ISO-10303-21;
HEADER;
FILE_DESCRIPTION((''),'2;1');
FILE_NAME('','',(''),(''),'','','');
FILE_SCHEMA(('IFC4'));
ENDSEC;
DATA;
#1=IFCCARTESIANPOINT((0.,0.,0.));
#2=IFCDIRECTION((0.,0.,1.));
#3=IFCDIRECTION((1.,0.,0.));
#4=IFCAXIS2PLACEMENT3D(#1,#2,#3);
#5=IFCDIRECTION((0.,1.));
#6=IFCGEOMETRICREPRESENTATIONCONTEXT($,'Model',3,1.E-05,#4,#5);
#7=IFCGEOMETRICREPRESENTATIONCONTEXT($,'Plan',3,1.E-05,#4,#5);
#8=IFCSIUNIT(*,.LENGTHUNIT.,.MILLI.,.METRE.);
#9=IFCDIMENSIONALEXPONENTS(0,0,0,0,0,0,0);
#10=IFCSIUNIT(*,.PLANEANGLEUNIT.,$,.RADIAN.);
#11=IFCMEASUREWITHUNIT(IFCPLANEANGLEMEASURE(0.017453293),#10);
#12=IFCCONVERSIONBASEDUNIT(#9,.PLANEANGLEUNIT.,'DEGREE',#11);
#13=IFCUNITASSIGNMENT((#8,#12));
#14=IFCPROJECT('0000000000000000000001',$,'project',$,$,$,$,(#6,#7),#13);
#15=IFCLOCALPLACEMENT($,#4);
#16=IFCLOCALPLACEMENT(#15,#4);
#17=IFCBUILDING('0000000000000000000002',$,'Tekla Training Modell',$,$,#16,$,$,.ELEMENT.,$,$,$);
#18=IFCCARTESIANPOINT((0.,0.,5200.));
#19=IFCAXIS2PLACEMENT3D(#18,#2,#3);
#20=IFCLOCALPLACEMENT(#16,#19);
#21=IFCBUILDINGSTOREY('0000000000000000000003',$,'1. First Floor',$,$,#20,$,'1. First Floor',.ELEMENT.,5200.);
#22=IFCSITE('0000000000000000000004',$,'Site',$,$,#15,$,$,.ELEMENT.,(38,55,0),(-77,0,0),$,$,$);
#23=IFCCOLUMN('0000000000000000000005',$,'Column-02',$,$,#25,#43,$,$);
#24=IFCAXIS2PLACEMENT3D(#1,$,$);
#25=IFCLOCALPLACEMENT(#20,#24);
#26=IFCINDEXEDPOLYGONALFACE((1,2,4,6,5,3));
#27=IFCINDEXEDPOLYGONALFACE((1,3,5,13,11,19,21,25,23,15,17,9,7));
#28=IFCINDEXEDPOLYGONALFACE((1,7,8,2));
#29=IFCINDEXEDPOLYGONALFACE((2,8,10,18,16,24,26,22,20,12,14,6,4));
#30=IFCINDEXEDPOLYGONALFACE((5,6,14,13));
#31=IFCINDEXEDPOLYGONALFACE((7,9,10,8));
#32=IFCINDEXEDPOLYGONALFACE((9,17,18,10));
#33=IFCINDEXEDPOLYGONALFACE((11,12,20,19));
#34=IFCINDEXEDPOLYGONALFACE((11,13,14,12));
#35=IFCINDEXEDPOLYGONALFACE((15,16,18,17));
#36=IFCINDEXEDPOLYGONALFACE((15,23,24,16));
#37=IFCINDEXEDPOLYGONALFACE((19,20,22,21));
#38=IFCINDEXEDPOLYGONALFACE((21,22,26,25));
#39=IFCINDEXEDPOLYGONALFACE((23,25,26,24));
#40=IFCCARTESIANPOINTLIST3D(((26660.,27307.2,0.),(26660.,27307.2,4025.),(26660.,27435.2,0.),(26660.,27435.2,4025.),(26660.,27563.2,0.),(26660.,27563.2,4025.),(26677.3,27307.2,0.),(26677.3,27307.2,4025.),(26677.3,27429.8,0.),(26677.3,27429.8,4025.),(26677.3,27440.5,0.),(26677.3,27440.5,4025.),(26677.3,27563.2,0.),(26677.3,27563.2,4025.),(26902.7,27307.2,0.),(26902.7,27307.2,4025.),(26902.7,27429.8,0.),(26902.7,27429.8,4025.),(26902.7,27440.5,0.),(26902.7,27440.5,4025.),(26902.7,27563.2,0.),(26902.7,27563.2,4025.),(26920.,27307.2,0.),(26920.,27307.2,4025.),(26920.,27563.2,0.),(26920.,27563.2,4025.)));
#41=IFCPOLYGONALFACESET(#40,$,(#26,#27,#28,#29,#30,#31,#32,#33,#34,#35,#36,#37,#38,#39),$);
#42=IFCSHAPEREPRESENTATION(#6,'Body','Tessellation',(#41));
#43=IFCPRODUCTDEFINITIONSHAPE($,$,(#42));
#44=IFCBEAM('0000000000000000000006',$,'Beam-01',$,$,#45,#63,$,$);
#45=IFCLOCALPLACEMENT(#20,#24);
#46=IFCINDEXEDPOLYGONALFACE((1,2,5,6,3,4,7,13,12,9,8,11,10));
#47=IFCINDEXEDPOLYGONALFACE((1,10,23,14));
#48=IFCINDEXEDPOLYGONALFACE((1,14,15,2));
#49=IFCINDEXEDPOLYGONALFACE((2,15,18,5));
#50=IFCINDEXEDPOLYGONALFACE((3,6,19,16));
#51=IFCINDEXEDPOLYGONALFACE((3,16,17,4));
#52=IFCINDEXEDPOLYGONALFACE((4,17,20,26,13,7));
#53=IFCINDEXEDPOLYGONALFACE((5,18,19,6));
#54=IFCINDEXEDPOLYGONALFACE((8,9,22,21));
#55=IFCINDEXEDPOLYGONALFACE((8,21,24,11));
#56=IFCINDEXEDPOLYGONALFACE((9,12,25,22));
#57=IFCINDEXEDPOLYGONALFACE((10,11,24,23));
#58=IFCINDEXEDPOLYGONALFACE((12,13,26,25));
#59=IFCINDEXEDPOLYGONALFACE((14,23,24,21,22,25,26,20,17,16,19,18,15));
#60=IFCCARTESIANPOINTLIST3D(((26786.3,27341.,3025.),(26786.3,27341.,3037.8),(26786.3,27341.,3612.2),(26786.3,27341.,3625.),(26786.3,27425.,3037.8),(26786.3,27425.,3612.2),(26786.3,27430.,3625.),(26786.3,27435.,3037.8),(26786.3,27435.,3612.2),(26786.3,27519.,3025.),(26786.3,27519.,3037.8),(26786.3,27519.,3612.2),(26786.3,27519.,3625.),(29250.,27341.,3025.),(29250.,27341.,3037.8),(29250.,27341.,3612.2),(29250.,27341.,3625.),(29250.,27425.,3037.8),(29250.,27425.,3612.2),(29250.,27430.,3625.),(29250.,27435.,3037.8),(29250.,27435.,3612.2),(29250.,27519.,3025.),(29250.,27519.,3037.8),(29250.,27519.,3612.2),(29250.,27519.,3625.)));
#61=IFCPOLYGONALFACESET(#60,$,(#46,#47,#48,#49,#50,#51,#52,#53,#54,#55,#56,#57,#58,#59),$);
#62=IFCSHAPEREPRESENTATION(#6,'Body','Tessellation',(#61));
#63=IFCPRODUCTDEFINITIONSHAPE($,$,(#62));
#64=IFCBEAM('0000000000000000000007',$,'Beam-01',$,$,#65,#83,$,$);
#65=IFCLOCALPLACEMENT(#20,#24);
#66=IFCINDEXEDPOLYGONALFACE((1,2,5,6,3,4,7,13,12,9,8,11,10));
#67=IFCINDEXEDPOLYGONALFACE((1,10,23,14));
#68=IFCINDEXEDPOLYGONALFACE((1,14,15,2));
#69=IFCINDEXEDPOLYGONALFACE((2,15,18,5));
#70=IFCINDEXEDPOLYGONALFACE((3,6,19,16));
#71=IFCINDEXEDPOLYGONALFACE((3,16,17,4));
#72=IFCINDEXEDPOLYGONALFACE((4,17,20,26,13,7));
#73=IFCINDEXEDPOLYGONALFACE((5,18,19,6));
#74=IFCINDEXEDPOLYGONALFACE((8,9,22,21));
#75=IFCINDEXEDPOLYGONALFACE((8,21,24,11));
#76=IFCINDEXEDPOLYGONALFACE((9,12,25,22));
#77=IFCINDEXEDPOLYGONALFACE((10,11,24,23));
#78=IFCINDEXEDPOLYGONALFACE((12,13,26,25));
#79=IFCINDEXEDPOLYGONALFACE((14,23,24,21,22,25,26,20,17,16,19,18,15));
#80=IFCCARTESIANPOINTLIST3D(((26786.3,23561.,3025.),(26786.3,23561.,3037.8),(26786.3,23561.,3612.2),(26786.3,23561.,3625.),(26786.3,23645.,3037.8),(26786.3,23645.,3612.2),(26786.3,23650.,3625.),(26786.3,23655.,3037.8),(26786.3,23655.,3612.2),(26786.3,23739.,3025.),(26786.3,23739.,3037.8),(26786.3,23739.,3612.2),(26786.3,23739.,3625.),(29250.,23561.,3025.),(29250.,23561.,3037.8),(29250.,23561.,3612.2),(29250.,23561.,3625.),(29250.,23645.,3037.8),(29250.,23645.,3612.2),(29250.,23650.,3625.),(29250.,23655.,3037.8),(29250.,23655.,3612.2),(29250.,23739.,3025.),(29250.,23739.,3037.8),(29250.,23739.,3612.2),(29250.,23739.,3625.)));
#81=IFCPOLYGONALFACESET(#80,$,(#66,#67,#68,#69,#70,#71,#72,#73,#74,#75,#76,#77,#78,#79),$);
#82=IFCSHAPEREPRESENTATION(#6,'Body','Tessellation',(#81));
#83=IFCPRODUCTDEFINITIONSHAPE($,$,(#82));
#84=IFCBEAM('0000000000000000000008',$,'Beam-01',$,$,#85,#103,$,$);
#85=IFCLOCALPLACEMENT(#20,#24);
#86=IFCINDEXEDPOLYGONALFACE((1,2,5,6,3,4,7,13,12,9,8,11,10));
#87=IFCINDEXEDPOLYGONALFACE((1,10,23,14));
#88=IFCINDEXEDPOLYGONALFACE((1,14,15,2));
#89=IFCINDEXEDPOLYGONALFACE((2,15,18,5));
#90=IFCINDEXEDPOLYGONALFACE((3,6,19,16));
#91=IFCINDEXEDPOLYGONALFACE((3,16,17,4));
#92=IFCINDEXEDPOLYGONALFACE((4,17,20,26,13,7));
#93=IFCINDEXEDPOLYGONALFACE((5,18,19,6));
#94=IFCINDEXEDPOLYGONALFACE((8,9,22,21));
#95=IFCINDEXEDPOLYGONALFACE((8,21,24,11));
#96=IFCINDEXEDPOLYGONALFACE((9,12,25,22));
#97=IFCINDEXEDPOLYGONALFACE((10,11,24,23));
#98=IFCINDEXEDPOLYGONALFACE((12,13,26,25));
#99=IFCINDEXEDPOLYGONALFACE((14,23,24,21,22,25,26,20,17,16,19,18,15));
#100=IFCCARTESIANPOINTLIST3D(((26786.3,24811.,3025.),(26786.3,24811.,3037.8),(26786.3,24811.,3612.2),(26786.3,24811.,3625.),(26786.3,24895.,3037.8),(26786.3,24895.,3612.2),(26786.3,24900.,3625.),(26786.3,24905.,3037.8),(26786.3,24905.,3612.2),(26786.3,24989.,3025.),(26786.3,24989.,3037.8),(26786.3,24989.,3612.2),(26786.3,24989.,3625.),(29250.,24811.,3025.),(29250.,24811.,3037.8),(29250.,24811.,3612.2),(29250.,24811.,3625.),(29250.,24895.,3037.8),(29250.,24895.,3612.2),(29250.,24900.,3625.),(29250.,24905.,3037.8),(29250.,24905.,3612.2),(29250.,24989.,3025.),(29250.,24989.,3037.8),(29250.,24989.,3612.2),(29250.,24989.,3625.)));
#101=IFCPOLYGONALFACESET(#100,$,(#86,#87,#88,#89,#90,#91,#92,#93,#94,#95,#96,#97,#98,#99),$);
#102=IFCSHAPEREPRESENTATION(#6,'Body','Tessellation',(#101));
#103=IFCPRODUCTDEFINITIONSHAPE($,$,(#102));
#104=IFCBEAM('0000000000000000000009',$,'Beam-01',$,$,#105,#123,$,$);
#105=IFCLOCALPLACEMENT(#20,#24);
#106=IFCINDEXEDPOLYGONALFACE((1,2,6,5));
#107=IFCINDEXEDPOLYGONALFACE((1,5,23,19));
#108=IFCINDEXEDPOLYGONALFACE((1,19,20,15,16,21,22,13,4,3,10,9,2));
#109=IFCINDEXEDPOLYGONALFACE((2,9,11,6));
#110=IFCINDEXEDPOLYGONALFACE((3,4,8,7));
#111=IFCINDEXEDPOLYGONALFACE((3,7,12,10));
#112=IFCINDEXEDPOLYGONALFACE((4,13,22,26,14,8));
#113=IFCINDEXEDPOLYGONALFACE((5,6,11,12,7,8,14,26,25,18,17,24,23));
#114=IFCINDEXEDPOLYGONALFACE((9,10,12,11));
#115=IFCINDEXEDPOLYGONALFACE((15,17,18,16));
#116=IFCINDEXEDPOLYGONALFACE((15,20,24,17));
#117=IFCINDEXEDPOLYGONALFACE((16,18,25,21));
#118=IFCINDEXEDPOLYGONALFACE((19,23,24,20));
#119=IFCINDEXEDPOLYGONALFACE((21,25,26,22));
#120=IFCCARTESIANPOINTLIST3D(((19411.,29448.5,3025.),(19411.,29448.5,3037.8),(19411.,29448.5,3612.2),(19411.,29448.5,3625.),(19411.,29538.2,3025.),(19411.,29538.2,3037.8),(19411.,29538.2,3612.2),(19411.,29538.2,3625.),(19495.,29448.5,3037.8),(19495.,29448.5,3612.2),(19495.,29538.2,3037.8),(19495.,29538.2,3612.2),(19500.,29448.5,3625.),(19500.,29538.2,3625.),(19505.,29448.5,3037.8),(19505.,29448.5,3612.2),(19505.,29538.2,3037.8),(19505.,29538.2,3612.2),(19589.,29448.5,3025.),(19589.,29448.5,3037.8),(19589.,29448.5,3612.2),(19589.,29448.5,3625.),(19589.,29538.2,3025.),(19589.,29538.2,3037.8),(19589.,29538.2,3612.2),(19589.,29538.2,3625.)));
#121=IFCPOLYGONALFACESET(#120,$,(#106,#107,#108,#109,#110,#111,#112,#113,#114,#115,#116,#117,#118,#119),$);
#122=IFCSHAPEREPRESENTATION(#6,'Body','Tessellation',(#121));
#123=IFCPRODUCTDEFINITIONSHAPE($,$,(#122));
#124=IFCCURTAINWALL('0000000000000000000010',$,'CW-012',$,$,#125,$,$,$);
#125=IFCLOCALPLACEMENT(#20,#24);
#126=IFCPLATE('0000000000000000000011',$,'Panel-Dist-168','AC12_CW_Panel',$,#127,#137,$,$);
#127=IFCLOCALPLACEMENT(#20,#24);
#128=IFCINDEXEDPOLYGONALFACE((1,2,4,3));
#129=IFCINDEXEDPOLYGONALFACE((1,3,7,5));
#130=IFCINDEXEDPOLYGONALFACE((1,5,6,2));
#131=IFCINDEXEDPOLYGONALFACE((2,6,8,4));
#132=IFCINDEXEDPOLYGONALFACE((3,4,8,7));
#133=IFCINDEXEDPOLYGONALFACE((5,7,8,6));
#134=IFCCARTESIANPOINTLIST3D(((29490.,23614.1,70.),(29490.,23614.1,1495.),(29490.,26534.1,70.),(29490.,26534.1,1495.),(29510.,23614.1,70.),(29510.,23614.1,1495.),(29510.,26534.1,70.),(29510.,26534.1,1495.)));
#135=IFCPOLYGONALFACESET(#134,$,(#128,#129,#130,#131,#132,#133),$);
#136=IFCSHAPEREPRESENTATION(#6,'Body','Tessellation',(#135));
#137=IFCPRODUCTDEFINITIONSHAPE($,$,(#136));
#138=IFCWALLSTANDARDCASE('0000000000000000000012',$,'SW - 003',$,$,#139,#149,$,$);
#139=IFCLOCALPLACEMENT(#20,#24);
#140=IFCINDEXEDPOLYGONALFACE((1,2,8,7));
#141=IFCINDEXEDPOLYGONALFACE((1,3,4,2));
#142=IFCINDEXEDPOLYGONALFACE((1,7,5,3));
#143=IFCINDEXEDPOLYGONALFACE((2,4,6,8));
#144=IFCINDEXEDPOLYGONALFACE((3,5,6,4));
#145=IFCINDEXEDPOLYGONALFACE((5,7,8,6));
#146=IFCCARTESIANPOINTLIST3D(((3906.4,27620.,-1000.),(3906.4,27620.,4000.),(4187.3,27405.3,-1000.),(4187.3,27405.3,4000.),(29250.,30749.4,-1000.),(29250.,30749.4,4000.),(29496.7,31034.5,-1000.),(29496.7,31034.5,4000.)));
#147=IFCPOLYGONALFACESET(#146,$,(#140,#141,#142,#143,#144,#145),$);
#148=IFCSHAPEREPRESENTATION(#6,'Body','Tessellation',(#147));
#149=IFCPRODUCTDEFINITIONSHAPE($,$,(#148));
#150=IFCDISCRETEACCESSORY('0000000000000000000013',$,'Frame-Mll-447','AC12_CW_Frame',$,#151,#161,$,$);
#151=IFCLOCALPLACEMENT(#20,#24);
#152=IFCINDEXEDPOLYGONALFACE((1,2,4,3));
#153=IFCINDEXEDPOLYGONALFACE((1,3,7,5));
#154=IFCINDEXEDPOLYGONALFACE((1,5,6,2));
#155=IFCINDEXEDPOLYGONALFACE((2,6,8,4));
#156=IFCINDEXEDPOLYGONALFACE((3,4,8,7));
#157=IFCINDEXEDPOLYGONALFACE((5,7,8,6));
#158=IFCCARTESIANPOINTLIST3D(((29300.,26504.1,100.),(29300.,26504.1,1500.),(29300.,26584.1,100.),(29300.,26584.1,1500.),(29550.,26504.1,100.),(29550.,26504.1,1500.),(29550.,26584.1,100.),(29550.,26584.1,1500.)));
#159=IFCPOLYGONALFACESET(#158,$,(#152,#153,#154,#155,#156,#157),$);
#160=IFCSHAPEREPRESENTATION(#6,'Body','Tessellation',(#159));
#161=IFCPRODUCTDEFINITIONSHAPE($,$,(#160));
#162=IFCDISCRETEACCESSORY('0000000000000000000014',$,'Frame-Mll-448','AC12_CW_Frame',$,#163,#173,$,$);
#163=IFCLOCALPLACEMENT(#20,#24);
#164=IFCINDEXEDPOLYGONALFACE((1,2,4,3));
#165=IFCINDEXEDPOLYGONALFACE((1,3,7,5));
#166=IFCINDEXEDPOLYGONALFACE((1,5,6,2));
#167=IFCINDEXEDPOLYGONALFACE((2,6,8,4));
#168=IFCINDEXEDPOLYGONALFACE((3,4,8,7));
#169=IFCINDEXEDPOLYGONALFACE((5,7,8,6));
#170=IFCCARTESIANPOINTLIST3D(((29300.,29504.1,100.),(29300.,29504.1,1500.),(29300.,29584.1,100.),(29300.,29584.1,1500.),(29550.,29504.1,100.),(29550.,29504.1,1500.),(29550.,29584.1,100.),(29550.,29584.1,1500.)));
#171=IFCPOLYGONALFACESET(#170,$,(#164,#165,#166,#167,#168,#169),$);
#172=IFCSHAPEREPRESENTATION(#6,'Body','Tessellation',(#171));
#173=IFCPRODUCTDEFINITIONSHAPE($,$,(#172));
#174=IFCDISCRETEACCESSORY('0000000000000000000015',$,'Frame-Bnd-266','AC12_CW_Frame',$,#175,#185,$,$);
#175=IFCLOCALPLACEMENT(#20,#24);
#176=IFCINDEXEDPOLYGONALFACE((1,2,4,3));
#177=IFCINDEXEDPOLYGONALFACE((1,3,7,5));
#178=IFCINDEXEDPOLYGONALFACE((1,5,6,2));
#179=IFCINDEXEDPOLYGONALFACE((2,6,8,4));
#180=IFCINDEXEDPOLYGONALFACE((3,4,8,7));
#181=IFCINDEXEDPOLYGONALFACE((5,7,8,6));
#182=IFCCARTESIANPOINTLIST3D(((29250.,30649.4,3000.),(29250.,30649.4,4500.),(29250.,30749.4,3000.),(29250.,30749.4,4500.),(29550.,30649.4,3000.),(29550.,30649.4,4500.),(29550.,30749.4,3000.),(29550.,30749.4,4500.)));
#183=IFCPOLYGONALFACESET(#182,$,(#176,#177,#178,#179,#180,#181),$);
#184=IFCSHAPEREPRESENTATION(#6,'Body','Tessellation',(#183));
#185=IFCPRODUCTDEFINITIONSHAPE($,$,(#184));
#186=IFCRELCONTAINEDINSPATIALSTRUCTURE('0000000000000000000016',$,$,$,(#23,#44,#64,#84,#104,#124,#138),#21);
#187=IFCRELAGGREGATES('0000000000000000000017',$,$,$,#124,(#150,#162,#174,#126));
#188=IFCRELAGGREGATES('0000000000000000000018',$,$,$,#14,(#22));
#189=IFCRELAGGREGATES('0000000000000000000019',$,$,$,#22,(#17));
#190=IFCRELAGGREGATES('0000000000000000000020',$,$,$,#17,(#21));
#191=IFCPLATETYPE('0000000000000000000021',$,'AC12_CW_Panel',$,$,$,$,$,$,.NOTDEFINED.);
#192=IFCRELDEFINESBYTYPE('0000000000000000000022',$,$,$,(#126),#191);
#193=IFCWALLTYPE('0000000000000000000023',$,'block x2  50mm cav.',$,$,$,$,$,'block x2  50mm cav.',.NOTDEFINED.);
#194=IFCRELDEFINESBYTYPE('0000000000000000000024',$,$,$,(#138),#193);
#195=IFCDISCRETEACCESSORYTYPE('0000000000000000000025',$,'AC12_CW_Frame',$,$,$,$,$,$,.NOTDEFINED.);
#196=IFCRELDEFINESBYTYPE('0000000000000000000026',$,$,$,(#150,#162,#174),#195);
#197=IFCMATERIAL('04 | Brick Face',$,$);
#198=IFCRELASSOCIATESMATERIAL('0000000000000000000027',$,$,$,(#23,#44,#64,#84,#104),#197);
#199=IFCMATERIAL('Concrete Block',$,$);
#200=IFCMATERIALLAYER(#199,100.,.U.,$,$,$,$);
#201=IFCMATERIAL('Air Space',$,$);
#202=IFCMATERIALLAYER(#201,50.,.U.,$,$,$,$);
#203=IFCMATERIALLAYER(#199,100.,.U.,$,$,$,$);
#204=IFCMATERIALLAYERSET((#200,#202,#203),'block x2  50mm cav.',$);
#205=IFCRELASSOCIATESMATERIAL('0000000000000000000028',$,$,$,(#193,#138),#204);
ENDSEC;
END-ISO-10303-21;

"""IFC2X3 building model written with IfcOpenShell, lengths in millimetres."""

from ifc_helpers import new_model, entity, si_unit, converted_unit, direction, frame, origin_with_axes, place, context, project, spatial, polyline, outline, extrude, source, transform, mapped, material, layer, layer_set, layer_usage, type_object, element, aggregate, save


model = new_model("IFC2X3")

# Units and contexts
model_context = context("Model", 3, precision=1e-05, world=origin_with_axes(), true_north=direction((0.0, 1.0)))
plan_context = context("Plan", 3, precision=1e-05, world=origin_with_axes(), true_north=direction((0.0, 1.0)))
ifc_project = project(units=[si_unit("LENGTHUNIT", "METRE", prefix="MILLI"), converted_unit("PLANEANGLEUNIT", "DEGREE", entity("IfcPlaneAngleMeasure", 0.017453293), si_unit("PLANEANGLEUNIT", "RADIAN"), dimensions=[0, 0, 0, 0, 0, 0, 0])], contexts=[model_context, plan_context])

# Site, building, storey
site_placement = place(None, origin_with_axes())
site = spatial("IfcSite", under=ifc_project, at=site_placement, Name="Site", CompositionType="ELEMENT", RefLatitude=(38, 55, 0), RefLongitude=(-77, 0, 0))
building_placement = place(site_placement, origin_with_axes())
building = spatial("IfcBuilding", under=site, at=building_placement, Name="Tekla Training Modell", CompositionType="ELEMENT")
storey_placement = place(building_placement, frame((0.0, 0.0, 5200.0), z_axis=(0.0, 0.0, 1.0), x_axis=(1.0, 0.0, 0.0)))
storey = spatial("IfcBuildingStorey", under=building, at=storey_placement, Name="1. First Floor", LongName="1. First Floor", CompositionType="ELEMENT", Elevation=5200.0)

# Column
ifc_material_1 = material(Name="04 | Brick Face")
for number, where, z_axis, x_axis, name in (
    (1, (26790.0, 27435.2, 0.0), (0.0, 0.0, 1.0), (0.0, 1.0, 0.0), "Column-02"),
):
    element("IfcColumn", number, at=place(storey_placement, frame(where, z_axis=z_axis, x_axis=x_axis)), inside=storey, material=ifc_material_1, Name=name, context=model_context, shape_type="SweptSolid", body=[
        extrude(outline(polyline([(0.0, 130.0), (-128.0, 130.0), (-128.0, 112.7), (-5.3, 112.7), (-5.3, -112.7), (-128.0, -112.7), (-128.0, -130.0), (128.0, -130.0), (128.0, -112.7), (5.3, -112.7), (5.3, 112.7), (128.0, 112.7), (128.0, 130.0), (0.0, 130.0)])), origin_with_axes(), (0.0, 0.0, 1.0), 4025.0),
    ])

# Beams
for number, where, z_axis, x_axis, name in (
    (2, (26786.3, 27430.0, 3325.0), (0.0, 0.0, 1.0), (0.0, -1.0, 0.0), "Beam-01"),
    (3, (26786.3, 23650.0, 3325.0), (0.0, 0.0, 1.0), (0.0, -1.0, 0.0), "Beam-01"),
    (4, (26786.3, 24900.0, 3325.0), (0.0, 0.0, 1.0), (0.0, -1.0, 0.0), "Beam-01"),
):
    element("IfcBeam", number, at=place(storey_placement, frame(where, z_axis=z_axis, x_axis=x_axis)), inside=storey, material=ifc_material_1, Name=name, context=model_context, shape_type="SweptSolid", body=[
        extrude(outline(polyline([(0.0, 300.0), (-89.0, 300.0), (-89.0, 287.2), (-5.0, 287.2), (-5.0, -287.2), (-89.0, -287.2), (-89.0, -300.0), (89.0, -300.0), (89.0, -287.2), (5.0, -287.2), (5.0, 287.2), (89.0, 287.2), (89.0, 300.0), (0.0, 300.0)])), frame((0.0, 2463.7, 0.0), z_axis=(0.0, -1.0, 0.0), x_axis=(1.0, 0.0, 0.0)), (0.0, 0.0, 1.0), 2463.7),
    ])
beam_placement = place(storey_placement, frame((19500.0, 29538.2, 3325.0), z_axis=(0.0, 0.0, 1.0), x_axis=(-1.0, 0.0, 0.0)))
element("IfcBeam", 5, at=beam_placement, inside=storey, material=ifc_material_1, Name="Beam-01", context=model_context, shape_type="SweptSolid", body=[
    extrude(outline(polyline([(0.0, 300.0), (-89.0, 300.0), (-89.0, 287.2), (-5.0, 287.2), (-5.0, -287.2), (-89.0, -287.2), (-89.0, -300.0), (89.0, -300.0), (89.0, -287.2), (5.0, -287.2), (5.0, 287.2), (89.0, 287.2), (89.0, 300.0), (0.0, 300.0)])), frame((0.0, 89.8, 0.0), z_axis=(0.0, -1.0, 0.0), x_axis=(1.0, 0.0, 0.0)), (0.0, 0.0, 1.0), 89.8),
])

# Curtain wall, plate
curtain_wall_1_placement = place(storey_placement, frame((29500.0, 23544.1, 0.0), z_axis=(0.0, 0.0, 1.0), x_axis=(0.0, 1.0, 0.0)))
curtain_wall_1 = element("IfcCurtainWall", 6, at=curtain_wall_1_placement, inside=storey, Name="CW-012")
plate_type = type_object("IfcPlateType", Name="AC12_CW_Panel", PredefinedType="NOTDEFINED")
shared_shape_1 = source(origin_with_axes(), model_context, "Body", "SweptSolid", [
    extrude(outline(polyline([(0.0, 0.0), (2920.0, 0.0), (2920.0, -20.0), (0.0, -20.0), (0.0, 0.0)])), origin_with_axes(), (0.0, 0.0, 1.0), 1425.0),
])
plate_placement = place(storey_placement, frame((29490.0, 23614.1, 70.0), z_axis=(0.0, 0.0, 1.0), x_axis=(0.0, 1.0, 0.0)))
plate = element("IfcPlate", 7, at=plate_placement, type_object=plate_type, Name="Panel-Dist-168", Description="AC12_CW_Panel", context=model_context, shape_type="MappedRepresentation", body=[
    mapped(shared_shape_1, transform((0.0, 0.0, 0.0), scale=1.0)),
])

# Wall
ifc_material_2 = material(Name="Concrete Block")
ifc_layer_1 = layer(ifc_material_2, 100.0, ventilated="UNKNOWN")
ifc_material_3 = material(Name="Air Space")
ifc_layer_2 = layer(ifc_material_3, 50.0, ventilated="UNKNOWN")
ifc_layer_3 = layer(ifc_material_2, 100.0, ventilated="UNKNOWN")
ifc_layer_set = layer_set([ifc_layer_1, ifc_layer_2, ifc_layer_3], Name="block x2  50mm cav.")
ifc_layer_usage = layer_usage(ifc_layer_set, "AXIS2", "NEGATIVE", 0.0)
wall_type = type_object("IfcWallType", Name="block x2  50mm cav.", ElementType="block x2  50mm cav.", PredefinedType="NOTDEFINED", material=ifc_layer_set)
wall_placement = place(storey_placement, frame((29250.0, 30749.4, -1000.0), z_axis=(0.0, 0.0, 1.0), x_axis=(-0.991216, -0.132256, 0.0)))
element("IfcWallStandardCase", 8, at=wall_placement, inside=storey, type_object=wall_type, material=ifc_layer_usage, Name="SW - 003", context=model_context, shape_type="SweptSolid", body=[
    extrude(outline(polyline([(-282.2, -250.0), (25534.8, -250.0), (25284.8, 0.0), (0.0, 0.0), (-282.2, -250.0)])), origin_with_axes(), (0.0, 0.0, 1.0), 5000.0),
])

# Discrete accessories
discrete_accessory_type = type_object("IfcDiscreteAccessoryType", Name="AC12_CW_Frame")
shared_shape_2 = source(origin_with_axes(), model_context, "Body", "SweptSolid", [
    extrude(outline(polyline([(0.0, 0.0), (250.0, 0.0), (250.0, -1400.0), (0.0, -1400.0), (0.0, 0.0)])), origin_with_axes(), (0.0, 0.0, 1.0), 80.0),
])
discrete_accessory_1_placement = place(storey_placement, frame((29300.0, 26504.1, 100.0), z_axis=(0.0, 1.0, 0.0), x_axis=(1.0, 0.0, 0.0)))
discrete_accessory_1 = element("IfcDiscreteAccessory", 9, at=discrete_accessory_1_placement, type_object=discrete_accessory_type, Name="Frame-Mll-447", Description="AC12_CW_Frame", context=model_context, shape_type="MappedRepresentation", body=[
    mapped(shared_shape_2, transform((0.0, 0.0, 0.0), scale=1.0)),
])
discrete_accessory_2_placement = place(storey_placement, frame((29300.0, 29504.1, 100.0), z_axis=(0.0, 1.0, 0.0), x_axis=(1.0, 0.0, 0.0)))
discrete_accessory_2 = element("IfcDiscreteAccessory", 10, at=discrete_accessory_2_placement, type_object=discrete_accessory_type, Name="Frame-Mll-448", Description="AC12_CW_Frame", context=model_context, shape_type="MappedRepresentation", body=[
    mapped(shared_shape_2, transform((0.0, 0.0, 0.0), scale=1.0)),
])
shared_shape_3 = source(origin_with_axes(), model_context, "Body", "SweptSolid", [
    extrude(outline(polyline([(0.0, 0.0), (300.0, 0.0), (300.0, -1500.0), (0.0, -1500.0), (0.0, 0.0)])), origin_with_axes(), (0.0, 0.0, 1.0), 100.0),
])
discrete_accessory_3_placement = place(storey_placement, frame((29250.0, 30649.4, 3000.0), z_axis=(0.0, 1.0, 0.0), x_axis=(1.0, 0.0, 0.0)))
discrete_accessory_3 = element("IfcDiscreteAccessory", 11, at=discrete_accessory_3_placement, type_object=discrete_accessory_type, Name="Frame-Bnd-266", Description="AC12_CW_Frame", context=model_context, shape_type="MappedRepresentation", body=[
    mapped(shared_shape_3, transform((0.0, 0.0, 0.0), scale=1.0)),
])

aggregate(curtain_wall_1, [discrete_accessory_1, discrete_accessory_2, discrete_accessory_3, plate])

save(model, "model.ifc")
